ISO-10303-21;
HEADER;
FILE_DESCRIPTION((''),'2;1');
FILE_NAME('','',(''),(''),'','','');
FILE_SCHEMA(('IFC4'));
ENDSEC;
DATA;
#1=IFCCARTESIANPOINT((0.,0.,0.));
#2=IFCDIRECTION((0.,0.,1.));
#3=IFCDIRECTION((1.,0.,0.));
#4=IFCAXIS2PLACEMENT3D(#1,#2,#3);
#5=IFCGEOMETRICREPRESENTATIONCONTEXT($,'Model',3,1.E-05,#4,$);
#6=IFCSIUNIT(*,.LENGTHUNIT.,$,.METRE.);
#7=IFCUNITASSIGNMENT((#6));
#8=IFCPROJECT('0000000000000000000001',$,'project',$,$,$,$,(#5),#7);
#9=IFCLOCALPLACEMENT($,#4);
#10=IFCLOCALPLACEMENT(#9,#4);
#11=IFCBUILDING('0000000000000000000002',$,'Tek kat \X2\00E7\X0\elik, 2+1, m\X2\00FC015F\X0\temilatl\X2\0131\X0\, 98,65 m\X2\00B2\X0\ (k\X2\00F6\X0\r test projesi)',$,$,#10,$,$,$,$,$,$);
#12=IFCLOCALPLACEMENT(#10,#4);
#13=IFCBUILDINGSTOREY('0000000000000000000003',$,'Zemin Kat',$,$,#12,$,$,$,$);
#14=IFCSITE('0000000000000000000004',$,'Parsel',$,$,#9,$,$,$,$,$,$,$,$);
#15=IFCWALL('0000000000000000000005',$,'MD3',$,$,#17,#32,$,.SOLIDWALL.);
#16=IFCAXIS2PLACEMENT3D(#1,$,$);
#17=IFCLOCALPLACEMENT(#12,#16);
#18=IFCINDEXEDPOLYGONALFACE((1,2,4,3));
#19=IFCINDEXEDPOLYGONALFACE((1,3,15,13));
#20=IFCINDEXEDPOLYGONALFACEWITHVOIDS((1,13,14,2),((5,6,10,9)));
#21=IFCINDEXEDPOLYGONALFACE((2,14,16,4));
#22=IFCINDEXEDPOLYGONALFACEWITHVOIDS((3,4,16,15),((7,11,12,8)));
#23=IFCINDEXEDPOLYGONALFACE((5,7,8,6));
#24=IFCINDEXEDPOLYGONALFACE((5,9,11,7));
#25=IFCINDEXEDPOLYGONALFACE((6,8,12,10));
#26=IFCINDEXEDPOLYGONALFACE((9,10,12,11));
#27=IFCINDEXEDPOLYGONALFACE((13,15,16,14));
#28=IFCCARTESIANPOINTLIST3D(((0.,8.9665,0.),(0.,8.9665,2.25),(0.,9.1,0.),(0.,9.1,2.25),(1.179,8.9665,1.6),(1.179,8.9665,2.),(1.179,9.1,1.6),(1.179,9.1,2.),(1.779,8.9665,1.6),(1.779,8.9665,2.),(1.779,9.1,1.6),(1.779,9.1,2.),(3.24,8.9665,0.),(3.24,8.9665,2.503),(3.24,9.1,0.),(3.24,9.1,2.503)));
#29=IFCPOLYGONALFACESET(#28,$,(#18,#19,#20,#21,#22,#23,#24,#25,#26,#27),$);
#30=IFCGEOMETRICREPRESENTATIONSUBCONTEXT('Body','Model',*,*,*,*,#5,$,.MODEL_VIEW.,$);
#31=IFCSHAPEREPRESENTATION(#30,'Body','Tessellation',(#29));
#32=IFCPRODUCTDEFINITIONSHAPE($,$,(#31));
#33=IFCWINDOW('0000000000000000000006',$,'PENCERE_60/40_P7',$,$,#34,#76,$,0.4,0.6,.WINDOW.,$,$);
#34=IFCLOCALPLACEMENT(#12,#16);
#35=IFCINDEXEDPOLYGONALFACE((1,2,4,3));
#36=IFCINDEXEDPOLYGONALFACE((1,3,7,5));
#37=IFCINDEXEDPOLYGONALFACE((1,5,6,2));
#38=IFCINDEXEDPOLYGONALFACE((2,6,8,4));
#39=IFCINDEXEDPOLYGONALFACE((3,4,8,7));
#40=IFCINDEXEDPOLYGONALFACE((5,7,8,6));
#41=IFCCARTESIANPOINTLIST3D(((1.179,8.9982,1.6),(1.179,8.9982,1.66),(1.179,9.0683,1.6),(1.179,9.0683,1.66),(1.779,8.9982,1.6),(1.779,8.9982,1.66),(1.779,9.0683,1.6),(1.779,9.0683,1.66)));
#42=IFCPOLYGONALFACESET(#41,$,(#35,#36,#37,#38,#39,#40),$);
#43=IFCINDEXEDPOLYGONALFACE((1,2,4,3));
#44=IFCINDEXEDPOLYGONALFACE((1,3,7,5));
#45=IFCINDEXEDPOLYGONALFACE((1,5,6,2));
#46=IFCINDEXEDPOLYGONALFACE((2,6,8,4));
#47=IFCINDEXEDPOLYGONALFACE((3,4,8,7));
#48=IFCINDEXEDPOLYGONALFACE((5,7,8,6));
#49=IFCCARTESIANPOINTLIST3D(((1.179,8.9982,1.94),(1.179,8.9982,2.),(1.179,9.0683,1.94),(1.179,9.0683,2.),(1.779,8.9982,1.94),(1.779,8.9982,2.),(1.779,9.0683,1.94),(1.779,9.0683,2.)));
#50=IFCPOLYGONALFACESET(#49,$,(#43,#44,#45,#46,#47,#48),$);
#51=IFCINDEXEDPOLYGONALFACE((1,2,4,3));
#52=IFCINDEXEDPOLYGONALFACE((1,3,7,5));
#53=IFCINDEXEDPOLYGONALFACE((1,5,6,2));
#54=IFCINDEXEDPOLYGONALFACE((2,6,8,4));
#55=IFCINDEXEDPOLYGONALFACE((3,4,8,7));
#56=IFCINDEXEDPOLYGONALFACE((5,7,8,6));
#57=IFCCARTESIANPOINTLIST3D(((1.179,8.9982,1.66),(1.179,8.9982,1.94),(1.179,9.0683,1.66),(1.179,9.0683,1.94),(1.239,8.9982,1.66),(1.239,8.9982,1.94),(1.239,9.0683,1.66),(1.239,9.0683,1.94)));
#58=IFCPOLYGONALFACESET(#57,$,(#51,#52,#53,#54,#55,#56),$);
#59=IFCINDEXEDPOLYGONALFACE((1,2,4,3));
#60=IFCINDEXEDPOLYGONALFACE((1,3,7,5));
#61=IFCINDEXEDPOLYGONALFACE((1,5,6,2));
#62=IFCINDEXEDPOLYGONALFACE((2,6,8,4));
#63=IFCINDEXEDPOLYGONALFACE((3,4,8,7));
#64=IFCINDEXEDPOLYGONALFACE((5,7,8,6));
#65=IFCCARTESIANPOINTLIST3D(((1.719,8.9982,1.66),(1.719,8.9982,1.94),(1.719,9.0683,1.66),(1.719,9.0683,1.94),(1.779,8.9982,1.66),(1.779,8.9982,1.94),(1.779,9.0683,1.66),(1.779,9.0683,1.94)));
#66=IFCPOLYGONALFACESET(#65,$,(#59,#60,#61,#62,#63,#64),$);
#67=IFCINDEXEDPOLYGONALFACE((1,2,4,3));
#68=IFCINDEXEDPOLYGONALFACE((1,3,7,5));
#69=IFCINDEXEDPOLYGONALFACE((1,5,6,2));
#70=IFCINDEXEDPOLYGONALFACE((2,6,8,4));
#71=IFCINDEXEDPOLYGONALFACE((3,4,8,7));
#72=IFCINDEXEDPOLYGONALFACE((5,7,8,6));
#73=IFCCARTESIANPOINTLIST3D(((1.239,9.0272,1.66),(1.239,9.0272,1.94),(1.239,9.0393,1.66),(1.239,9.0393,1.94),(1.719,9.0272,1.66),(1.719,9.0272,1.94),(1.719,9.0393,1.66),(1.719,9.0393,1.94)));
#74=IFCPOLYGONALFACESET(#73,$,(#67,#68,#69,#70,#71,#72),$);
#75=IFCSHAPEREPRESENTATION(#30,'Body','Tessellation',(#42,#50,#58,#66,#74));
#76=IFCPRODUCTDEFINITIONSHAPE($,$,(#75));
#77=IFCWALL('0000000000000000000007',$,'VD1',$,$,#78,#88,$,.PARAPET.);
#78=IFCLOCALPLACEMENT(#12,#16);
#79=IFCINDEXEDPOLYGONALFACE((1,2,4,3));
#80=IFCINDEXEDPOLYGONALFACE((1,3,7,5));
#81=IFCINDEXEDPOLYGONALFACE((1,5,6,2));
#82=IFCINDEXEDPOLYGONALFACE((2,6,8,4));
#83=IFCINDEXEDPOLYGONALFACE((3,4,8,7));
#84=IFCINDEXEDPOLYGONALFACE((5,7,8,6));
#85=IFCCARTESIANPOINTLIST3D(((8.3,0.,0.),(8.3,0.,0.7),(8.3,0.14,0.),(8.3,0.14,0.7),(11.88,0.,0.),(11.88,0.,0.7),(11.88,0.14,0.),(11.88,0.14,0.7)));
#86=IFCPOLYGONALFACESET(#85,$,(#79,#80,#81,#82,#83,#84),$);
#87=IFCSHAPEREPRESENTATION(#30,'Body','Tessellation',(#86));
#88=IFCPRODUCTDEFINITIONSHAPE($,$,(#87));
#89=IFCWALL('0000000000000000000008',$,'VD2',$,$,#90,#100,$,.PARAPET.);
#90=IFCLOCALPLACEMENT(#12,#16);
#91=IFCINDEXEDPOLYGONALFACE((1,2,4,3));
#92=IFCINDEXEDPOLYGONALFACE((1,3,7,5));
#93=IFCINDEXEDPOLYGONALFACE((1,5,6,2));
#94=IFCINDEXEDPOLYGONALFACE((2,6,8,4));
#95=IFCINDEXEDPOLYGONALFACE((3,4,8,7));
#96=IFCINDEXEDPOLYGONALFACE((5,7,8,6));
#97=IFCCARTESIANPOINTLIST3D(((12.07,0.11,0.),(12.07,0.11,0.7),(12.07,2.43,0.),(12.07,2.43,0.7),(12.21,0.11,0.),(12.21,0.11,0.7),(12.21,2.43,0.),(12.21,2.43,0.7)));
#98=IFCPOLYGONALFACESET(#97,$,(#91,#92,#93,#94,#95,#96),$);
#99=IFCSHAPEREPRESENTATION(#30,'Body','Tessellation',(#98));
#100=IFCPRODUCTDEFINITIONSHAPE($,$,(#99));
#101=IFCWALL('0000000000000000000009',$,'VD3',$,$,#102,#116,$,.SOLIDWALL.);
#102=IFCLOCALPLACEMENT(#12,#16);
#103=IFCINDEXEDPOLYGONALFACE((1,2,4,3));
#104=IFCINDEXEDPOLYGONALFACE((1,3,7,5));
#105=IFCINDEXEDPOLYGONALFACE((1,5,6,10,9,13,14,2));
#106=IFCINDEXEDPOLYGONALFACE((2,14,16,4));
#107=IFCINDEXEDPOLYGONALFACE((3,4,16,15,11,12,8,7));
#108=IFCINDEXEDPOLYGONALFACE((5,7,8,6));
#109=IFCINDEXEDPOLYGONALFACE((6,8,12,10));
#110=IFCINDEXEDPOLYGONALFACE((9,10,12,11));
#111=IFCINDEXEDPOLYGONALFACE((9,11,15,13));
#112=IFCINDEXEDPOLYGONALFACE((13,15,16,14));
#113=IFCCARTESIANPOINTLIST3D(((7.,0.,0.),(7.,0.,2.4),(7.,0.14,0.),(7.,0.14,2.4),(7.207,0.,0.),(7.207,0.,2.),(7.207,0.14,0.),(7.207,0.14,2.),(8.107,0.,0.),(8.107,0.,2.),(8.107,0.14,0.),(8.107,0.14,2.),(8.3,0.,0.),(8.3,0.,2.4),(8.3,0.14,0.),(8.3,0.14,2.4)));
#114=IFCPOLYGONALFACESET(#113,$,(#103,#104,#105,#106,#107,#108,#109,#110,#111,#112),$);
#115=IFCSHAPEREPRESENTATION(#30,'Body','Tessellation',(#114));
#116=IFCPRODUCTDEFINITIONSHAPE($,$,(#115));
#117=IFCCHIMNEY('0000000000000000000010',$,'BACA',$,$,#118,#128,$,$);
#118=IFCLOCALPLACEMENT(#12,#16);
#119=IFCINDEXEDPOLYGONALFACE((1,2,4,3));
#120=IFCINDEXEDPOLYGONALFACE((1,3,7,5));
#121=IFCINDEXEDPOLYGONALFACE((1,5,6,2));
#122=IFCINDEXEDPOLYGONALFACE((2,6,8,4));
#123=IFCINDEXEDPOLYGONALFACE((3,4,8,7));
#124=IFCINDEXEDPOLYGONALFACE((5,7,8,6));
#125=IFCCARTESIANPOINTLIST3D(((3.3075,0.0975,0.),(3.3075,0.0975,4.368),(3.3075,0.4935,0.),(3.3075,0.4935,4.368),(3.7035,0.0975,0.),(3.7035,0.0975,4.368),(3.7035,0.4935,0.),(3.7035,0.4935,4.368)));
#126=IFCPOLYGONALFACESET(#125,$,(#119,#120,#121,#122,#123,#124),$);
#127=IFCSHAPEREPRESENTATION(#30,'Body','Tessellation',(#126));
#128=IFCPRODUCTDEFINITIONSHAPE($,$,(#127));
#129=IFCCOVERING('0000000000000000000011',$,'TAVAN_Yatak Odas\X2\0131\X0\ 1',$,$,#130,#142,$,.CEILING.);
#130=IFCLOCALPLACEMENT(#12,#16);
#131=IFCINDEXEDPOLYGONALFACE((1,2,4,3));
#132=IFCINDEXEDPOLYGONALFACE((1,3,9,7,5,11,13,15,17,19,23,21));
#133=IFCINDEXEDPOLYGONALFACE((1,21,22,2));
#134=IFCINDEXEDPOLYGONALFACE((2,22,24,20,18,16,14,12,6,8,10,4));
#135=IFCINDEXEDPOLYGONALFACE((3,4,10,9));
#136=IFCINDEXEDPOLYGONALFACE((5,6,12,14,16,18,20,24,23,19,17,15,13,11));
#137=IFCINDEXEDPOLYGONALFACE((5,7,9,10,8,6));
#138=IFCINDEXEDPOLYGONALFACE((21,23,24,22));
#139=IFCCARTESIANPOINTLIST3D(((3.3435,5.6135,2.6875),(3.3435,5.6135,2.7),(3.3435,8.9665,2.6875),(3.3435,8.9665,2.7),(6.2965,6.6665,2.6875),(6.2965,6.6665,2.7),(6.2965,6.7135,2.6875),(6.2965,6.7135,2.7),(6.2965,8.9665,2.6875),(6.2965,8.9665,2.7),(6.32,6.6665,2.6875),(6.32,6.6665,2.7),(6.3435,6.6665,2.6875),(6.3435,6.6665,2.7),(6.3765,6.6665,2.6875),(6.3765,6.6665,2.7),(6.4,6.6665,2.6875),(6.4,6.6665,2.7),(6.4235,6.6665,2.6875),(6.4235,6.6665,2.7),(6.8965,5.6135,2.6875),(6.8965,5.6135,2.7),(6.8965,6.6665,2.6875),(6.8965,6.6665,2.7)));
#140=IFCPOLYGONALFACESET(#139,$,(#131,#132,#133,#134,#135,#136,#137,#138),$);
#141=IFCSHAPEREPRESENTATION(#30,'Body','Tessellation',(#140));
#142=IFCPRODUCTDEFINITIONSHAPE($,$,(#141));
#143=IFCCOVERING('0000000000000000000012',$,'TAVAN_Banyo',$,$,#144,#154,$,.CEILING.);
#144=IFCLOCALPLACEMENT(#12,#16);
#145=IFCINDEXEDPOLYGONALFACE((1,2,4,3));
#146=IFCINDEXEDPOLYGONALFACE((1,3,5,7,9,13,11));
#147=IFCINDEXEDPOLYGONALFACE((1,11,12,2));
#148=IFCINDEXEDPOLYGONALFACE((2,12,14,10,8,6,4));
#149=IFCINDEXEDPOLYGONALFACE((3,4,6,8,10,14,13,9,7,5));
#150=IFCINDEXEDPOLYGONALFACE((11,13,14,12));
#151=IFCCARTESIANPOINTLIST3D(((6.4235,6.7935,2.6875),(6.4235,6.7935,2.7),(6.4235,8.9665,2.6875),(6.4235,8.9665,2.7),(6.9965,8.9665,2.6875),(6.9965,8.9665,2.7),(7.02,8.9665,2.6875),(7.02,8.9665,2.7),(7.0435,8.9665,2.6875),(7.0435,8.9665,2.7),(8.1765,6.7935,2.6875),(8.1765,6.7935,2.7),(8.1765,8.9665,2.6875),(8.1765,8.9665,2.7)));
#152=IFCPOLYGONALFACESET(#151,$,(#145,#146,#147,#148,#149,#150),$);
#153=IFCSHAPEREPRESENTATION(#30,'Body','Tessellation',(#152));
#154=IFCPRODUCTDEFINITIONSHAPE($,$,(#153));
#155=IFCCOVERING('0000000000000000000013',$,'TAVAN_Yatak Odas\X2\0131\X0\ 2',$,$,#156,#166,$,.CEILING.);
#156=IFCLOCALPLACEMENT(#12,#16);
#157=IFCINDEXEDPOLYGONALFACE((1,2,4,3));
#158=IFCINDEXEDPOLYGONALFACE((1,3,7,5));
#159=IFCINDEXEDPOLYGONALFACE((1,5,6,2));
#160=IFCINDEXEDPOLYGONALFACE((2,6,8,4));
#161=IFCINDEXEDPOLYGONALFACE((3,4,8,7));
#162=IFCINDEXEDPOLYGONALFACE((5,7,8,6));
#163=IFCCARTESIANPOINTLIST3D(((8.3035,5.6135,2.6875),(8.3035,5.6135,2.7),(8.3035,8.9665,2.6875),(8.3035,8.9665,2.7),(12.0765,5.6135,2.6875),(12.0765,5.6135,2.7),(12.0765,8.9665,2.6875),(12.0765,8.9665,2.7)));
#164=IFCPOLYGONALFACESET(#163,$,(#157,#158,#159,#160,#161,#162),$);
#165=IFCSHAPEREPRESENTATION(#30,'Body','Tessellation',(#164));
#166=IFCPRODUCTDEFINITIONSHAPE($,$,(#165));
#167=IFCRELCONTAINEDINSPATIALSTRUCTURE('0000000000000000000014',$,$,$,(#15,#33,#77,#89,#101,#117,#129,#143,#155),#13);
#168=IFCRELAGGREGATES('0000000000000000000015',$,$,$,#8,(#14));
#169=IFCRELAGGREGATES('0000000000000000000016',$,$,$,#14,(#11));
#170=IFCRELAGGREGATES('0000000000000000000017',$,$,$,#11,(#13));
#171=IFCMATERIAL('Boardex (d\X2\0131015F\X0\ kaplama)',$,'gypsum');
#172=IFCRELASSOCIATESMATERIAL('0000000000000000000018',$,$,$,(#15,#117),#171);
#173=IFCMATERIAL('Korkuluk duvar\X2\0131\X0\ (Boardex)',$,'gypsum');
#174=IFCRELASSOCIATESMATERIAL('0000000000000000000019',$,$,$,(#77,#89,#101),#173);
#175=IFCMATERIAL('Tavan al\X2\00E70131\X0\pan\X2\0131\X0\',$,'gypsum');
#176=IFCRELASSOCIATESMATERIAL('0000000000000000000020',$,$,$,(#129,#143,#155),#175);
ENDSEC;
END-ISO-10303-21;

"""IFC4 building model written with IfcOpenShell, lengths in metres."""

from ifc_helpers import new_model, si_unit, frame, origin_with_axes, place, context, subcontext, project, spatial, line, indexed_curve, outline, extrude, material, element, fill, save


model = new_model("IFC4")

# Units and contexts
model_context = context("Model", 3, precision=1e-05, world=origin_with_axes())
body_context = subcontext(model_context, "Body", "Model", "MODEL_VIEW")
ifc_project = project(units=[si_unit("LENGTHUNIT", "METRE")], contexts=[model_context])

# Site, building, storey
site_placement = place(None, origin_with_axes())
site = spatial("IfcSite", under=ifc_project, at=site_placement, Name="Parsel")
building_placement = place(site_placement, origin_with_axes())
building = spatial("IfcBuilding", under=site, at=building_placement, Name="Tek kat çelik, 2+1, müştemilatlı, 98,65 m² (kör test projesi)")
storey_placement = place(building_placement, origin_with_axes())
storey = spatial("IfcBuildingStorey", under=building, at=storey_placement, Name="Zemin Kat")

# Shared definitions
ifc_material_1 = material(Name="Boardex (dış kaplama)", Category="gypsum")

# Wall, opening, window
wall_1_placement = place(storey_placement, origin_with_axes())
wall_1 = element("IfcWall", 1, at=wall_1_placement, inside=storey, material=ifc_material_1, Name="MD3", PredefinedType="SOLIDWALL", context=body_context, shape_type="SweptSolid", body=[
    extrude(outline(indexed_curve([(0.0, 0.0), (3.24, 0.0), (3.24, 2.503), (0.0, 2.25)], segments=[line(1, 2, 3, 4, 1)])), frame((0.0, 9.1, 0.0), z_axis=(0.0, -1.0, 0.0), x_axis=(1.0, 0.0, 0.0)), (0.0, 0.0, 1.0), 0.1335),
])
opening_1_placement = place(wall_1_placement, origin_with_axes())
opening_1 = element("IfcOpeningElement", 2, at=opening_1_placement, cuts=wall_1, PredefinedType="OPENING", context=body_context, shape_type="SweptSolid", body=[
    extrude(outline(indexed_curve([(0.0, 0.0), (0.6, 0.0), (0.6, 0.1735), (0.0, 0.1735)], segments=[line(1, 2, 3, 4, 1)])), frame((1.179, 8.9465, 1.6), z_axis=(0.0, 0.0, 1.0), x_axis=(1.0, 0.0, 0.0)), (0.0, 0.0, 1.0), 0.4),
])
window_placement = place(storey_placement, origin_with_axes())
window = element("IfcWindow", 3, at=window_placement, inside=storey, Name="PENCERE_60/40_P7", OverallHeight=0.4, OverallWidth=0.6, PredefinedType="WINDOW", context=body_context, shape_type="SweptSolid", body=[
    extrude(outline(indexed_curve([(0.0, 0.0), (0.6, 0.0), (0.6, 0.07), (0.0, 0.07)], segments=[line(1, 2, 3, 4, 1)])), frame((1.179, 8.9983, 1.6), z_axis=(0.0, 0.0, 1.0), x_axis=(1.0, 0.0, 0.0)), (0.0, 0.0, 1.0), 0.06),
    extrude(outline(indexed_curve([(0.0, 0.0), (0.6, 0.0), (0.6, 0.07), (0.0, 0.07)], segments=[line(1, 2, 3, 4, 1)])), frame((1.179, 8.9983, 1.94), z_axis=(0.0, 0.0, 1.0), x_axis=(1.0, 0.0, 0.0)), (0.0, 0.0, 1.0), 0.06),
    extrude(outline(indexed_curve([(0.0, 0.0), (0.06, 0.0), (0.06, 0.07), (0.0, 0.07)], segments=[line(1, 2, 3, 4, 1)])), frame((1.179, 8.9983, 1.66), z_axis=(0.0, 0.0, 1.0), x_axis=(1.0, 0.0, 0.0)), (0.0, 0.0, 1.0), 0.28),
    extrude(outline(indexed_curve([(0.0, 0.0), (0.06, 0.0), (0.06, 0.07), (0.0, 0.07)], segments=[line(1, 2, 3, 4, 1)])), frame((1.719, 8.9983, 1.66), z_axis=(0.0, 0.0, 1.0), x_axis=(1.0, 0.0, 0.0)), (0.0, 0.0, 1.0), 0.28),
    extrude(outline(indexed_curve([(0.0, 0.0), (0.48, 0.0), (0.48, 0.012), (0.0, 0.012)], segments=[line(1, 2, 3, 4, 1)])), frame((1.239, 9.0273, 1.66), z_axis=(0.0, 0.0, 1.0), x_axis=(1.0, 0.0, 0.0)), (0.0, 0.0, 1.0), 0.28),
])
fill(opening_1, window)

# Walls
ifc_material_2 = material(Name="Korkuluk duvarı (Boardex)", Category="gypsum")
wall_2_placement = place(storey_placement, origin_with_axes())
element("IfcWall", 4, at=wall_2_placement, inside=storey, material=ifc_material_2, Name="VD1", PredefinedType="PARAPET", context=body_context, shape_type="SweptSolid", body=[
    extrude(outline(indexed_curve([(0.0, 0.0), (3.58, 0.0), (3.58, 0.14), (0.0, 0.14)], segments=[line(1, 2, 3, 4, 1)])), frame((8.3, 0.0, 0.0), z_axis=(0.0, 0.0, 1.0), x_axis=(1.0, 0.0, 0.0)), (0.0, 0.0, 1.0), 0.7),
])
wall_3_placement = place(storey_placement, origin_with_axes())
element("IfcWall", 5, at=wall_3_placement, inside=storey, material=ifc_material_2, Name="VD2", PredefinedType="PARAPET", context=body_context, shape_type="SweptSolid", body=[
    extrude(outline(indexed_curve([(0.0, 0.0), (0.14, 0.0), (0.14, 2.32), (0.0, 2.32)], segments=[line(1, 2, 3, 4, 1)])), frame((12.07, 0.11, 0.0), z_axis=(0.0, 0.0, 1.0), x_axis=(1.0, 0.0, 0.0)), (0.0, 0.0, 1.0), 0.7),
])

# Wall, opening
wall_4_placement = place(storey_placement, origin_with_axes())
wall_4 = element("IfcWall", 6, at=wall_4_placement, inside=storey, material=ifc_material_2, Name="VD3", PredefinedType="SOLIDWALL", context=body_context, shape_type="SweptSolid", body=[
    extrude(outline(indexed_curve([(0.0, 0.0), (1.3, 0.0), (1.3, 0.14), (0.0, 0.14)], segments=[line(1, 2, 3, 4, 1)])), frame((7.0, 0.0, 0.0), z_axis=(0.0, 0.0, 1.0), x_axis=(1.0, 0.0, 0.0)), (0.0, 0.0, 1.0), 2.4),
])
opening_2_placement = place(wall_4_placement, origin_with_axes())
element("IfcOpeningElement", 7, at=opening_2_placement, cuts=wall_4, PredefinedType="OPENING", context=body_context, shape_type="SweptSolid", body=[
    extrude(outline(indexed_curve([(0.0, 0.0), (0.9, 0.0), (0.9, 0.18), (0.0, 0.18)], segments=[line(1, 2, 3, 4, 1)])), frame((7.207, -0.02, 0.0), z_axis=(0.0, 0.0, 1.0), x_axis=(1.0, 0.0, 0.0)), (0.0, 0.0, 1.0), 2.0),
])

# Chimney
chimney_placement = place(storey_placement, origin_with_axes())
element("IfcChimney", 8, at=chimney_placement, inside=storey, material=ifc_material_1, Name="BACA", context=body_context, shape_type="SweptSolid", body=[
    extrude(outline(indexed_curve([(0.0, 0.0), (0.396, 0.0), (0.396, 0.396), (0.0, 0.396)], segments=[line(1, 2, 3, 4, 1)])), frame((3.3075, 0.0975, 0.0), z_axis=(0.0, 0.0, 1.0), x_axis=(1.0, 0.0, 0.0)), (0.0, 0.0, 1.0), 4.368),
])

# Coverings
ifc_material_3 = material(Name="Tavan alçıpanı", Category="gypsum")
covering_1_placement = place(storey_placement, origin_with_axes())
element("IfcCovering", 9, at=covering_1_placement, inside=storey, material=ifc_material_3, Name="TAVAN_Yatak Odası 1", PredefinedType="CEILING", context=body_context, shape_type="SweptSolid", body=[
    extrude(outline(indexed_curve([(6.3435, 6.6665), (6.3765, 6.6665), (6.4, 6.6665), (6.4235, 6.6665), (6.8965, 6.6665), (6.8965, 5.6135), (3.3435, 5.6135), (3.3435, 8.9665), (6.2965, 8.9665), (6.2965, 6.7135), (6.2965, 6.6665), (6.32, 6.6665)], segments=[line(1, 2, 3, 4, 5, 6, 7, 8, 9, 10, 11, 12, 1)])), frame((0.0, 0.0, 2.6875), z_axis=(0.0, 0.0, 1.0), x_axis=(1.0, 0.0, 0.0)), (0.0, 0.0, 1.0), 0.0125),
])
covering_2_placement = place(storey_placement, origin_with_axes())
element("IfcCovering", 10, at=covering_2_placement, inside=storey, material=ifc_material_3, Name="TAVAN_Banyo", PredefinedType="CEILING", context=body_context, shape_type="SweptSolid", body=[
    extrude(outline(indexed_curve([(7.0435, 8.9665), (8.1765, 8.9665), (8.1765, 6.7935), (6.4235, 6.7935), (6.4235, 8.9665), (6.9965, 8.9665), (7.02, 8.9665)], segments=[line(1, 2, 3, 4, 5, 6, 7, 1)])), frame((0.0, 0.0, 2.6875), z_axis=(0.0, 0.0, 1.0), x_axis=(1.0, 0.0, 0.0)), (0.0, 0.0, 1.0), 0.0125),
])
covering_3_placement = place(storey_placement, origin_with_axes())
element("IfcCovering", 11, at=covering_3_placement, inside=storey, material=ifc_material_3, Name="TAVAN_Yatak Odası 2", PredefinedType="CEILING", context=body_context, shape_type="SweptSolid", body=[
    extrude(outline(indexed_curve([(8.3035, 8.9665), (12.0765, 8.9665), (12.0765, 5.6135), (8.3035, 5.6135)], segments=[line(1, 2, 3, 4, 1)])), frame((0.0, 0.0, 2.6875), z_axis=(0.0, 0.0, 1.0), x_axis=(1.0, 0.0, 0.0)), (0.0, 0.0, 1.0), 0.0125),
])

save(model, "model.ifc")
